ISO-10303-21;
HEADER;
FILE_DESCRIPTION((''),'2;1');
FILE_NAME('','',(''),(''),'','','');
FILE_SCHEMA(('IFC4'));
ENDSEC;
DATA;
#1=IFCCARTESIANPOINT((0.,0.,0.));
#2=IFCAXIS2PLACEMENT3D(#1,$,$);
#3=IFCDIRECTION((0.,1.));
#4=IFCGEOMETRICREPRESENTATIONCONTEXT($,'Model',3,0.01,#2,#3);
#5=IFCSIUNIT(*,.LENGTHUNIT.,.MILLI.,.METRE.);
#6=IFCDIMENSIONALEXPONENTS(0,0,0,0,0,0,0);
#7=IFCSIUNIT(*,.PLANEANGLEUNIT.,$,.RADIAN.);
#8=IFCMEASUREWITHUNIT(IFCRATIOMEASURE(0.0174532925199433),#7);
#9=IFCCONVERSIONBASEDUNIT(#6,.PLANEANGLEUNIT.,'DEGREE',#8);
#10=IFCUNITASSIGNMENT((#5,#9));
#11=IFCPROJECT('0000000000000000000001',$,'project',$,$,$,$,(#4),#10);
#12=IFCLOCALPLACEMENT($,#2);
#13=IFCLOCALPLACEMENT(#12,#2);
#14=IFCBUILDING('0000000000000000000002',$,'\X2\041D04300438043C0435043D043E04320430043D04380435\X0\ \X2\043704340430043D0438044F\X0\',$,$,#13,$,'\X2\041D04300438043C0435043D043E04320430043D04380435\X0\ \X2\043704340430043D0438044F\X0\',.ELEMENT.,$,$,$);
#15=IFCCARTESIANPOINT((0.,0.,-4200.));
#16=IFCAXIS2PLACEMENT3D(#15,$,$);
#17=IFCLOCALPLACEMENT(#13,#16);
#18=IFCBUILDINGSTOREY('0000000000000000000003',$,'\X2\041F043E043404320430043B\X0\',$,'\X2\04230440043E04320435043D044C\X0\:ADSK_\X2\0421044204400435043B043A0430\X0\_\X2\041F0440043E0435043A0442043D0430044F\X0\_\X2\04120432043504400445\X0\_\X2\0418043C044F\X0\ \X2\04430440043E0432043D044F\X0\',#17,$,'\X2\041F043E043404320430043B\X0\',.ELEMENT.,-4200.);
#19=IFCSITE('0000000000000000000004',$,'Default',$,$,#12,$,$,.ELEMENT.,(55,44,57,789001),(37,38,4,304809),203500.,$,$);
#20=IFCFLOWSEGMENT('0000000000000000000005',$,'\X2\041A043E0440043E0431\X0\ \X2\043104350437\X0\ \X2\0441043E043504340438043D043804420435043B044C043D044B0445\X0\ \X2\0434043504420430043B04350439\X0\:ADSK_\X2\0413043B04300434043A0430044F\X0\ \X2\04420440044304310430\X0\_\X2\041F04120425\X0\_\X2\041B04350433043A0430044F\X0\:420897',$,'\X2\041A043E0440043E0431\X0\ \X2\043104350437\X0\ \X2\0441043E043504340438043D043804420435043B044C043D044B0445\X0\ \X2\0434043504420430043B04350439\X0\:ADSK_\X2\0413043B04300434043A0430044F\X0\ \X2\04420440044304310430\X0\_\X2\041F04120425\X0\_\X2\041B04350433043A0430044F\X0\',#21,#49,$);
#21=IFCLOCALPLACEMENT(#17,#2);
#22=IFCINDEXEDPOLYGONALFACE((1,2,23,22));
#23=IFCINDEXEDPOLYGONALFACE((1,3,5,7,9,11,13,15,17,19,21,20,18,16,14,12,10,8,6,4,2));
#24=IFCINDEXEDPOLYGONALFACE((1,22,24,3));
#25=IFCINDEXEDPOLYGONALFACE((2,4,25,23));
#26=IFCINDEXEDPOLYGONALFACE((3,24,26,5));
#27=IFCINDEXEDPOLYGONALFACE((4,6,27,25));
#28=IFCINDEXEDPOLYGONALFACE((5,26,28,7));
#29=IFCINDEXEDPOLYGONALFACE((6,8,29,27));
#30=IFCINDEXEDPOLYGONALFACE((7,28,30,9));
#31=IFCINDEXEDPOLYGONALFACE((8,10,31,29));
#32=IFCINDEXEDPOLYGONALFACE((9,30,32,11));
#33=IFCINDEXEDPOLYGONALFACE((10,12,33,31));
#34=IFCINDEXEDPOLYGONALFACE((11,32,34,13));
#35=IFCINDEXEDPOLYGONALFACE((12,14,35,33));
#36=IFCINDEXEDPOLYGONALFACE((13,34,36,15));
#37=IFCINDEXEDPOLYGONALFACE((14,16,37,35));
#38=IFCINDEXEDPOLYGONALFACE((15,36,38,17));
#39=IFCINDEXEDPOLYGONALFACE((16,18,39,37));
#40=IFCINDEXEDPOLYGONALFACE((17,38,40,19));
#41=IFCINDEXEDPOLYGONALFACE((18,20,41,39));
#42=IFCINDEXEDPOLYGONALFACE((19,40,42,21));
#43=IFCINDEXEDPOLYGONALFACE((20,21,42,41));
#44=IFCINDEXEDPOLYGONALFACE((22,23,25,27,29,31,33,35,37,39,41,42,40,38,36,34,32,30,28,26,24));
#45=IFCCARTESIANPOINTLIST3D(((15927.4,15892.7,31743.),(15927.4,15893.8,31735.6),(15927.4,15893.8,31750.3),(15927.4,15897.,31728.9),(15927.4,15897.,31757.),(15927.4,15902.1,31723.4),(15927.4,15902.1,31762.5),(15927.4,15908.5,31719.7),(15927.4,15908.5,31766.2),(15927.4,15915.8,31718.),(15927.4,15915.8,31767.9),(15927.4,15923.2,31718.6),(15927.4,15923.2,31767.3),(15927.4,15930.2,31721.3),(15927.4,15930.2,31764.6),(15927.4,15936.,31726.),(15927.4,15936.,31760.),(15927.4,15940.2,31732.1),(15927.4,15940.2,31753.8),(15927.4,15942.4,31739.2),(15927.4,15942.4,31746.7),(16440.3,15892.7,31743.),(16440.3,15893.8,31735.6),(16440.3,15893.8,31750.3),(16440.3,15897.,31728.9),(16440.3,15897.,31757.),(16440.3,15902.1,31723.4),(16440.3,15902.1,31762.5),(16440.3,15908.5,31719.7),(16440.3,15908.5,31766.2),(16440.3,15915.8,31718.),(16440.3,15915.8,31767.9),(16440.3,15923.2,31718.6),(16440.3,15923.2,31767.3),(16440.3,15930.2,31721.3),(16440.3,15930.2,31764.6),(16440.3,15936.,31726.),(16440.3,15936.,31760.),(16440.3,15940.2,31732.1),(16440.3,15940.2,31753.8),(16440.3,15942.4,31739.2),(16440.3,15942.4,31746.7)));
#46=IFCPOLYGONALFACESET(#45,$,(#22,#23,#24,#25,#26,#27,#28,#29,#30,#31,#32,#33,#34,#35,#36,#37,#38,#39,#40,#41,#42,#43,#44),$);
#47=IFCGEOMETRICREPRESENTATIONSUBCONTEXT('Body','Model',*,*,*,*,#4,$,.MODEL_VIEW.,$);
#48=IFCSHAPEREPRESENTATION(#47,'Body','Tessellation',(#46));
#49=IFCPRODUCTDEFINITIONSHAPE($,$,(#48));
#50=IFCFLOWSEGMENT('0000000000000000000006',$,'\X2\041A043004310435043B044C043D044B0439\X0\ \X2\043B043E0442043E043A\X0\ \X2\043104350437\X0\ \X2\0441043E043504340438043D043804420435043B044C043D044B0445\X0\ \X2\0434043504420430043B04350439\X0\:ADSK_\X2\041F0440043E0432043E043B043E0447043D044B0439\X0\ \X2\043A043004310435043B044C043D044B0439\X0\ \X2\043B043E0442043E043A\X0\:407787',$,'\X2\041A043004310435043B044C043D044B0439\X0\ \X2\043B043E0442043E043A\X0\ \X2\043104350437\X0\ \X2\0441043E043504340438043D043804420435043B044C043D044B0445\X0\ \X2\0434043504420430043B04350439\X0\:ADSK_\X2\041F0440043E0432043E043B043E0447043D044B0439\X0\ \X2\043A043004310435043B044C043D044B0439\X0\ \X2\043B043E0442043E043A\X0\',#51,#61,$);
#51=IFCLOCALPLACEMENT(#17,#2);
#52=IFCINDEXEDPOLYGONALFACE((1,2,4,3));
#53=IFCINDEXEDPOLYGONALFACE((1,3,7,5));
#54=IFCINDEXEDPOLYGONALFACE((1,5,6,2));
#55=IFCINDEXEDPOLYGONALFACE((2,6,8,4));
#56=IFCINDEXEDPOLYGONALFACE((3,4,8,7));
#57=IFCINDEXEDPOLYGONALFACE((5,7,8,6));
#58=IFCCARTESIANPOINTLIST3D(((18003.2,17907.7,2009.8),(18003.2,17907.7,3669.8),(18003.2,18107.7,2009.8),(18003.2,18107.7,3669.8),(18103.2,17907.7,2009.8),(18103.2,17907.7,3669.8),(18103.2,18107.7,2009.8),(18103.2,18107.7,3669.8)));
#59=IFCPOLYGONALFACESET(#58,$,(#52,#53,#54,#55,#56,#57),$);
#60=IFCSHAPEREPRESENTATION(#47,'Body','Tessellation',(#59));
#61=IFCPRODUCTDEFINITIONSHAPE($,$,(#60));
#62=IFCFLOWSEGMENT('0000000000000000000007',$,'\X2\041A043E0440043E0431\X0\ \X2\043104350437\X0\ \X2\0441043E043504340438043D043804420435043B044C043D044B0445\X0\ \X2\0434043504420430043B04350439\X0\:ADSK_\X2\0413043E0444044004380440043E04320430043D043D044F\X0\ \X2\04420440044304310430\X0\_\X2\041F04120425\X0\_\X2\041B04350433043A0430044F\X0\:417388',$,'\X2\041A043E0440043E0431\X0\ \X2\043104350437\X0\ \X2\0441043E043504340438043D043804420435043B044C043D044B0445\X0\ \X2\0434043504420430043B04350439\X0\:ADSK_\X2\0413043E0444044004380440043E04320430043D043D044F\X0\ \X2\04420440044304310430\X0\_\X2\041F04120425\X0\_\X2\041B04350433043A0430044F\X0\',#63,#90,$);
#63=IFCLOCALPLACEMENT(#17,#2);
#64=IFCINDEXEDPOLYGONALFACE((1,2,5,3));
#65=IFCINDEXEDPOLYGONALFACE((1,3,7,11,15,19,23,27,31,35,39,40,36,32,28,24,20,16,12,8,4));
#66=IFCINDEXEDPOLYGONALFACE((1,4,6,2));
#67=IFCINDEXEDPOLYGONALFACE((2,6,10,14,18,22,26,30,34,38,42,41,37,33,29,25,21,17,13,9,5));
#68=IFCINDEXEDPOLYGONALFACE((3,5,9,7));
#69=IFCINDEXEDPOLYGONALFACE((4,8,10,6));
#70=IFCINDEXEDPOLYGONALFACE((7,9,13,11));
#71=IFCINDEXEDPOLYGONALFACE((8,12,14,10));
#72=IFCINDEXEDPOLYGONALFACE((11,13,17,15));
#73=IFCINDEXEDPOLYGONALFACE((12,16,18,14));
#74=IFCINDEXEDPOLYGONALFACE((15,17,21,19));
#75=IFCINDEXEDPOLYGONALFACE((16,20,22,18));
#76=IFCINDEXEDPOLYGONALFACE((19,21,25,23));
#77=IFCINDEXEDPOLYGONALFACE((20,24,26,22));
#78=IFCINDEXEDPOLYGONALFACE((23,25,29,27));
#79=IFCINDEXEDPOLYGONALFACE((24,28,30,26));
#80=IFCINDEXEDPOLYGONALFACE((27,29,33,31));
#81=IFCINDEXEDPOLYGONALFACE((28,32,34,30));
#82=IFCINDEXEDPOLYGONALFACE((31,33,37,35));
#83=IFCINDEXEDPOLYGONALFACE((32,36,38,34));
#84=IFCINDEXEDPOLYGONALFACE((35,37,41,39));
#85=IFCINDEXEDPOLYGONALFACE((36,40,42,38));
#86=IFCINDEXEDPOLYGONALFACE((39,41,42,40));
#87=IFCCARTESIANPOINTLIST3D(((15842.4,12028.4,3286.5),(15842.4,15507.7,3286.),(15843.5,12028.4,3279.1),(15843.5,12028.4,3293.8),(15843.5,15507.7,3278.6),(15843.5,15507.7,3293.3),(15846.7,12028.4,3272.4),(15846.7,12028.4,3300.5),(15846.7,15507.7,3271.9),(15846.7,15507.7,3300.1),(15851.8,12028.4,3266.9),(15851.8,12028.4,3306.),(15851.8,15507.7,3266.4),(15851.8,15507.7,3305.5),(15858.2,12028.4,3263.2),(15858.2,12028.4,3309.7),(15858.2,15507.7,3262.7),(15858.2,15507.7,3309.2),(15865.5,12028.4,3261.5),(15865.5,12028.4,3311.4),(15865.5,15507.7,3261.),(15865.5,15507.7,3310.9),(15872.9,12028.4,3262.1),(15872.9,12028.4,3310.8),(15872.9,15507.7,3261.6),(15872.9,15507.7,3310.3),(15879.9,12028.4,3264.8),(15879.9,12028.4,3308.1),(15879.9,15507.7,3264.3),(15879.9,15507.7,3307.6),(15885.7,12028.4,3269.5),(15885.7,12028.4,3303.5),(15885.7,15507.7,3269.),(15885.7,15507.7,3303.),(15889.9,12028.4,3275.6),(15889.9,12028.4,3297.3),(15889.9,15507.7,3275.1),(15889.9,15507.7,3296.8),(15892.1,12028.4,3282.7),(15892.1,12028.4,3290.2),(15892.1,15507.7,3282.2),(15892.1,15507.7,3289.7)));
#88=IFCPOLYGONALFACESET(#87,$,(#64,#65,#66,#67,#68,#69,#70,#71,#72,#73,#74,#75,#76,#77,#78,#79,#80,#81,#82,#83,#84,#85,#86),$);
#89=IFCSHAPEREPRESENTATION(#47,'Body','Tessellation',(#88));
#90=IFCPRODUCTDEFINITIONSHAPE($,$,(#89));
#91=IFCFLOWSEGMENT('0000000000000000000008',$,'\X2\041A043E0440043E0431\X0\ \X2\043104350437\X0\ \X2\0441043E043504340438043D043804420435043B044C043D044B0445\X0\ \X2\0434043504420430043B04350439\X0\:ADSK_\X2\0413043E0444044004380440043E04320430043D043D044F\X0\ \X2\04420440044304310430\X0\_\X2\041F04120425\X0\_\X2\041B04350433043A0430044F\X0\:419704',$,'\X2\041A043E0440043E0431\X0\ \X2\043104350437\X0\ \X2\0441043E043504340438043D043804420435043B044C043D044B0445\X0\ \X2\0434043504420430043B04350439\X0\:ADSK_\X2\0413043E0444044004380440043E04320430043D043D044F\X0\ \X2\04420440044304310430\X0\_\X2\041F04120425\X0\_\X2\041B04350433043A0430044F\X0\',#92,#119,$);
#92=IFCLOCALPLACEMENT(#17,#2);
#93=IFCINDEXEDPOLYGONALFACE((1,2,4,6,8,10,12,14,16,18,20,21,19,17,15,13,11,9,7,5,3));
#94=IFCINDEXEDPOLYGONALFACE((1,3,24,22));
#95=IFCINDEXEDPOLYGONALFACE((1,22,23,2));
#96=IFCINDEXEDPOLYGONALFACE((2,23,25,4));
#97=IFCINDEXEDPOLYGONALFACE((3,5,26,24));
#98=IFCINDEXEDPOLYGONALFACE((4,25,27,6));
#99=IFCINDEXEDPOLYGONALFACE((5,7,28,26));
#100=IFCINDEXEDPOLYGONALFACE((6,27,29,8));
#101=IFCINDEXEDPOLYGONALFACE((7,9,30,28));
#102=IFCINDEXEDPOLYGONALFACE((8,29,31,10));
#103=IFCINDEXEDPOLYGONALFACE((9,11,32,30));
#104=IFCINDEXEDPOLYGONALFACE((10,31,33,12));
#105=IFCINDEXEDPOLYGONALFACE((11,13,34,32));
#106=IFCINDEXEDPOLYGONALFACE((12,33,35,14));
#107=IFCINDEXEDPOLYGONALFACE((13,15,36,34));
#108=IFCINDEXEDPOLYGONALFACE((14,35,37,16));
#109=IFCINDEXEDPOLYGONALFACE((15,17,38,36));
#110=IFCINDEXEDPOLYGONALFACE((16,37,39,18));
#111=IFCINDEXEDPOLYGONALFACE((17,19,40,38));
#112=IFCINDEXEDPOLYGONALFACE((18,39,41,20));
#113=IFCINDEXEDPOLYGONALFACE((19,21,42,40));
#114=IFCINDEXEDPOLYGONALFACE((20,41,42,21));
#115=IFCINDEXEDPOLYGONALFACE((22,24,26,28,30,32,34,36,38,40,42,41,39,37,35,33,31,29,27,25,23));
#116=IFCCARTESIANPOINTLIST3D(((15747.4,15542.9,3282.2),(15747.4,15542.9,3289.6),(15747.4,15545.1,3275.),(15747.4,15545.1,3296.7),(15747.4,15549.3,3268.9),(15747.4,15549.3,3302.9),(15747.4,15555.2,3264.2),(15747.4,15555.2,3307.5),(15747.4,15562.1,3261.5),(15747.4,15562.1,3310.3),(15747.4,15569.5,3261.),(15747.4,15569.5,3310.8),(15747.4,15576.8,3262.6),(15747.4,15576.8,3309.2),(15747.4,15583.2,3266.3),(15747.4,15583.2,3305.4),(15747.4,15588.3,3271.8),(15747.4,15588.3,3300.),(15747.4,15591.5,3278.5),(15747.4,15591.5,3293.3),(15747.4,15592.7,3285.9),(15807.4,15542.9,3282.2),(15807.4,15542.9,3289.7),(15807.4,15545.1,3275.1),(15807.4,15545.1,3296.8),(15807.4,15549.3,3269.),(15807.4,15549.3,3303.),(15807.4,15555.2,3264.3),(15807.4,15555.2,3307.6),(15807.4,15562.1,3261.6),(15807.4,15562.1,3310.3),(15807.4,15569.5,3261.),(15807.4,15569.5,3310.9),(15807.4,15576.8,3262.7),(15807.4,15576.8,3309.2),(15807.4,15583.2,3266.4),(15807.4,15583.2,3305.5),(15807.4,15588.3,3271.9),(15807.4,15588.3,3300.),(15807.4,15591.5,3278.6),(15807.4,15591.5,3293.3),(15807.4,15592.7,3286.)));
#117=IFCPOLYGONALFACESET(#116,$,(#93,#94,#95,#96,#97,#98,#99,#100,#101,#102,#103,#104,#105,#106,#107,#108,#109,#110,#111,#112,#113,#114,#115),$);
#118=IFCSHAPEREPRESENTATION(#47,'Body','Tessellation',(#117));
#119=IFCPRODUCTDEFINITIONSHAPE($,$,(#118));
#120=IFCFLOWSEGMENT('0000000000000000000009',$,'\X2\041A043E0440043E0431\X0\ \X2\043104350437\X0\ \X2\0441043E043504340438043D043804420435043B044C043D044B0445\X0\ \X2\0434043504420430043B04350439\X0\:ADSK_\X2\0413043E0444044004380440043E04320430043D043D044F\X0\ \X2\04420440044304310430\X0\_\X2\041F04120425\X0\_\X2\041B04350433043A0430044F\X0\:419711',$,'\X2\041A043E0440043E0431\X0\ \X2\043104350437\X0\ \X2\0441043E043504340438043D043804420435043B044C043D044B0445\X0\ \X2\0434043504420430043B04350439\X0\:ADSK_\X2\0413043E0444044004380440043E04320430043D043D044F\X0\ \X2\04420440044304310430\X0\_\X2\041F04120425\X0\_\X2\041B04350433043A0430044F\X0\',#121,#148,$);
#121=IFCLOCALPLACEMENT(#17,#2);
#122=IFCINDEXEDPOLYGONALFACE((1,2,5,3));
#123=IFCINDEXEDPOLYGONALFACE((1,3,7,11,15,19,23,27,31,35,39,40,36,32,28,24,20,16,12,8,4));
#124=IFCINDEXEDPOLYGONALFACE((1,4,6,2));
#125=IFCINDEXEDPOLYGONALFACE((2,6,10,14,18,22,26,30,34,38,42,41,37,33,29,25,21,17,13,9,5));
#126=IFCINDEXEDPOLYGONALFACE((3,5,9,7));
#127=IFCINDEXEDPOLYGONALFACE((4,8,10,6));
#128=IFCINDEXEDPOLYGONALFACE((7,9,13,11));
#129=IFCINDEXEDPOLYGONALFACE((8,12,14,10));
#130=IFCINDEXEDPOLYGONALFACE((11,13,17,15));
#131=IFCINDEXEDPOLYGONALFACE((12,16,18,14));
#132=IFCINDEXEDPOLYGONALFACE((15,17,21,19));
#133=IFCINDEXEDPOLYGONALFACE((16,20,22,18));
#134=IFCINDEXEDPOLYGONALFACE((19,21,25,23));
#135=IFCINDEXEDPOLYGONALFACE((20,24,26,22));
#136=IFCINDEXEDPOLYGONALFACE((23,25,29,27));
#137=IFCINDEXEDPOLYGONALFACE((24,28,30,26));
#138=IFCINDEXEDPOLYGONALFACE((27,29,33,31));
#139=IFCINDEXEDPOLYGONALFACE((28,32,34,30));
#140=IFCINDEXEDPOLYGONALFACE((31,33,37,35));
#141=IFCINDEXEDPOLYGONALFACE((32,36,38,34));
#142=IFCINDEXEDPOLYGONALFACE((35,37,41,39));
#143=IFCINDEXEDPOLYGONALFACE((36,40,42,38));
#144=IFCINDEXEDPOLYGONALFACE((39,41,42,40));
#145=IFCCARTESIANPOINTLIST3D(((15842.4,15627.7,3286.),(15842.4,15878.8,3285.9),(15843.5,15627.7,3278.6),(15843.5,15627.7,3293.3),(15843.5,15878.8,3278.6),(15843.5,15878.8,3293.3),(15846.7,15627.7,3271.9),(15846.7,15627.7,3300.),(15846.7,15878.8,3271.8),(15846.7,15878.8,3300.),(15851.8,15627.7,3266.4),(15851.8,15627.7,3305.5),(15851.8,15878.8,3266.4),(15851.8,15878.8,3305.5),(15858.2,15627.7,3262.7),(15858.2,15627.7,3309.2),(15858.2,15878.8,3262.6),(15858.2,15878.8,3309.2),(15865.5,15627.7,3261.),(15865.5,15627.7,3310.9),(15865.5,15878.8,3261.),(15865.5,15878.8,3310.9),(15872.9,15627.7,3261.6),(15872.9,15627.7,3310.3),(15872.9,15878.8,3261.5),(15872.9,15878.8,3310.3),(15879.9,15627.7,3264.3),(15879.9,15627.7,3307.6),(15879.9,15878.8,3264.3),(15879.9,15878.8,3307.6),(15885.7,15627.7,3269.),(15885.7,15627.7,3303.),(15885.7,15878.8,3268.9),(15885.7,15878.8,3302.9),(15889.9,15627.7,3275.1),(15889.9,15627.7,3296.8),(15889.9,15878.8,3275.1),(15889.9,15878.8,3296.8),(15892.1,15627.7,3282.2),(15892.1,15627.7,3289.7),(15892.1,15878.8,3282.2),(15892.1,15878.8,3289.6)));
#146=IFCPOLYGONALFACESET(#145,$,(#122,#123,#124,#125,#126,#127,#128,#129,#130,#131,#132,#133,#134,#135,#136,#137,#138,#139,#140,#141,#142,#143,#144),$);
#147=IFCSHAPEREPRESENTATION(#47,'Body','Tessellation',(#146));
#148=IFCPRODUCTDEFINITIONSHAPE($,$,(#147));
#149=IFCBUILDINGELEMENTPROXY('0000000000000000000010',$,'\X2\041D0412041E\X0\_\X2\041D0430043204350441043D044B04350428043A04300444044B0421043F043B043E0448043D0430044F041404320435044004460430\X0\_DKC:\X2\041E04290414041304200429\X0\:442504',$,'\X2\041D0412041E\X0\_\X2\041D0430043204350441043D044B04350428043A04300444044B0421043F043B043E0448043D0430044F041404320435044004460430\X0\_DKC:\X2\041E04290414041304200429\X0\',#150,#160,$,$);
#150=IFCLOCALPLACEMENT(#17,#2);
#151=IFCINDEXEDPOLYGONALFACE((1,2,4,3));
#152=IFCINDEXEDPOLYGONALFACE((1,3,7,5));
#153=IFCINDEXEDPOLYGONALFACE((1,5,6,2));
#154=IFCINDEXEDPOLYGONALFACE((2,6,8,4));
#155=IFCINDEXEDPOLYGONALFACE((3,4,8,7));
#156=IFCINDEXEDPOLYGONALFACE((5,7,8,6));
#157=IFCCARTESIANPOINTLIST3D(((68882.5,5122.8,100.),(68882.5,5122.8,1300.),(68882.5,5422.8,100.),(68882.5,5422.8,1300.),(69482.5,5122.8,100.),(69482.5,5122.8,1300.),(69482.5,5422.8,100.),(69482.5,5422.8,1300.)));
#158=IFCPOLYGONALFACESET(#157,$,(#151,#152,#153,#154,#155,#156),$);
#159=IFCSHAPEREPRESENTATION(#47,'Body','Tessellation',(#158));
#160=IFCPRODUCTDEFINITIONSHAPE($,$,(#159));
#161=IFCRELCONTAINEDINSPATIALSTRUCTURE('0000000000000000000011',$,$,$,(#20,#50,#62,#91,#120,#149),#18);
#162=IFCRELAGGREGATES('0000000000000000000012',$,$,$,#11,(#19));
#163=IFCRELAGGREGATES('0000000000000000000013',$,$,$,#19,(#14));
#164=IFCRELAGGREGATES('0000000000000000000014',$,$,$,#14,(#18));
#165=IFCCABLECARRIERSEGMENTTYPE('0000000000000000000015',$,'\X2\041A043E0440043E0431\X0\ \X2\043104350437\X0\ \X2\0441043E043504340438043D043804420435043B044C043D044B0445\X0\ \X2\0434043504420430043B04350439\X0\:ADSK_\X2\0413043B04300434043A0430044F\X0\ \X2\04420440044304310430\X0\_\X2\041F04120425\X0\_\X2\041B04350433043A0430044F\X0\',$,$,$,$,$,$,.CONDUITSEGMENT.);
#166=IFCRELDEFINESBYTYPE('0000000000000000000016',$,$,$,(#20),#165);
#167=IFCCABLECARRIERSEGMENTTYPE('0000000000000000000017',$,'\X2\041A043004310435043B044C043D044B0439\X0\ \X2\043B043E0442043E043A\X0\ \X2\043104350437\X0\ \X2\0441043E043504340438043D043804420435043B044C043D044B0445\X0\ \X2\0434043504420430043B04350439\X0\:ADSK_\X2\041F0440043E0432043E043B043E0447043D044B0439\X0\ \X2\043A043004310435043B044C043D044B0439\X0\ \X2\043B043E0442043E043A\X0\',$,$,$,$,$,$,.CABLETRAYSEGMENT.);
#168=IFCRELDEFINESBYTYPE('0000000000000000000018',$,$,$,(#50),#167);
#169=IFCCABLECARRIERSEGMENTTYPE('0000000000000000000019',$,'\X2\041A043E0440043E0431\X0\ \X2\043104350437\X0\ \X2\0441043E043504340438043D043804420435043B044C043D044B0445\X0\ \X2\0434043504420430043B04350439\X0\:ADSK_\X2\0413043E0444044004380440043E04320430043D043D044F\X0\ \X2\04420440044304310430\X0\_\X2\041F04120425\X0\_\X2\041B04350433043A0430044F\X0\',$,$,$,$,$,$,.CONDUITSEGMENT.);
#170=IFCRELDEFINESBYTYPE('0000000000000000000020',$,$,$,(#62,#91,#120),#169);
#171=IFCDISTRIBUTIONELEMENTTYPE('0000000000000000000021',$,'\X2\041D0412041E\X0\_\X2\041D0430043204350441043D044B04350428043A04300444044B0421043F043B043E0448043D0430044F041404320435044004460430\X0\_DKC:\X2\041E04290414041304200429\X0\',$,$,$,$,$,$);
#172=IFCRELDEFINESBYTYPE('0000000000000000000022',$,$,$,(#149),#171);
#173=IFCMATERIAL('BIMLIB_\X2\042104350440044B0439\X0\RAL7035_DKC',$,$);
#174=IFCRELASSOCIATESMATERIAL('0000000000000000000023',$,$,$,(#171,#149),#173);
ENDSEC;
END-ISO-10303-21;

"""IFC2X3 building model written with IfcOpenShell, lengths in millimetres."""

from ifc_helpers import new_model, entity, si_unit, converted_unit, direction, frame, frame_2d, origin, origin_2d_with_axis, place, context, subcontext, project, spatial, rectangle, circle, extrude, source, transform, mapped, material, type_object, type_shapes, element, save


model = new_model("IFC2X3")

# Units and contexts
model_context = context("Model", 3, precision=0.01, world=origin(), true_north=direction((0.0, 1.0)))
body_context = subcontext(model_context, "Body", "Model", "MODEL_VIEW")
ifc_project = project(units=[si_unit("LENGTHUNIT", "METRE", prefix="MILLI"), converted_unit("PLANEANGLEUNIT", "DEGREE", entity("IfcRatioMeasure", 0.0174532925199433), si_unit("PLANEANGLEUNIT", "RADIAN"), dimensions=[0, 0, 0, 0, 0, 0, 0])], contexts=[model_context])

# Site, building, storey
site_placement = place(None, frame((0.0, 0.0, 0.0)))
site = spatial("IfcSite", under=ifc_project, at=site_placement, Name="Default", CompositionType="ELEMENT", RefLatitude=(55, 44, 57, 789001), RefLongitude=(37, 38, 4, 304809), RefElevation=203500.0)
building_placement = place(site_placement, origin())
building = spatial("IfcBuilding", under=site, at=building_placement, Name="Наименование здания", LongName="Наименование здания", CompositionType="ELEMENT")
storey_placement = place(building_placement, frame((0.0, 0.0, -4200.0)))
storey = spatial("IfcBuildingStorey", under=building, at=storey_placement, Name="Подвал", ObjectType="Уровень:ADSK_Стрелка_Проектная_Вверх_Имя уровня", LongName="Подвал", CompositionType="ELEMENT", Elevation=-4200.0)

# Flow segments
cable_carrier_segment_type_1 = type_object("IfcCableCarrierSegmentType", Name="Короб без соединительных деталей:ADSK_Гладкая труба_ПВХ_Легкая", PredefinedType="CONDUITSEGMENT")
flow_segment_1_placement = place(storey_placement, frame((15927.4, 15891.1, 31716.4)))
element("IfcFlowSegment", 1, at=flow_segment_1_placement, inside=storey, type_object=cable_carrier_segment_type_1, Name="Короб без соединительных деталей:ADSK_Гладкая труба_ПВХ_Легкая:420897", ObjectType="Короб без соединительных деталей:ADSK_Гладкая труба_ПВХ_Легкая", context=body_context, shape_type="SweptSolid", body=[
    extrude(circle(Radius=25.0, at=frame_2d((0.0, 0.0), x_axis=(1.0, 0.0))), frame((0.0, 26.6, 26.6), z_axis=(1.0, -0.000004, 0.0), x_axis=(-0.000004, -1.0, 0.0)), (0.0, 0.0, 1.0), 513.0),
])
cable_carrier_segment_type_2 = type_object("IfcCableCarrierSegmentType", Name="Кабельный лоток без соединительных деталей:ADSK_Проволочный кабельный лоток", PredefinedType="CABLETRAYSEGMENT")
flow_segment_2_placement = place(storey_placement, frame((18003.2, 17907.7, 2009.8)))
element("IfcFlowSegment", 2, at=flow_segment_2_placement, inside=storey, type_object=cable_carrier_segment_type_2, Name="Кабельный лоток без соединительных деталей:ADSK_Проволочный кабельный лоток:407787", ObjectType="Кабельный лоток без соединительных деталей:ADSK_Проволочный кабельный лоток", context=body_context, shape_type="SweptSolid", body=[
    extrude(rectangle(XDim=200.0, YDim=100.0, at=origin_2d_with_axis()), frame((50.0, 100.0, 0.0), z_axis=(0.0, 0.0, 1.0), x_axis=(0.0, 1.0, 0.0)), (0.0, 0.0, 1.0), 1660.0),
])
cable_carrier_segment_type_3 = type_object("IfcCableCarrierSegmentType", Name="Короб без соединительных деталей:ADSK_Гофрировання труба_ПВХ_Легкая", PredefinedType="CONDUITSEGMENT")
flow_segment_3_placement = place(storey_placement, frame((15840.8, 12028.4, 3259.4)))
element("IfcFlowSegment", 3, at=flow_segment_3_placement, inside=storey, type_object=cable_carrier_segment_type_3, Name="Короб без соединительных деталей:ADSK_Гофрировання труба_ПВХ_Легкая:417388", ObjectType="Короб без соединительных деталей:ADSK_Гофрировання труба_ПВХ_Легкая", context=body_context, shape_type="SweptSolid", body=[
    extrude(circle(Radius=25.0, at=frame_2d((0.0, 0.0), x_axis=(1.0, 0.0))), frame((26.6, 0.0, 27.1), z_axis=(0.0, 1.0, -0.000139), x_axis=(-1.0, 0.0, 0.0)), (0.0, 0.0, 1.0), 3479.2),
])
flow_segment_4_placement = place(storey_placement, frame((15747.4, 15541.1, 3259.3)))
element("IfcFlowSegment", 4, at=flow_segment_4_placement, inside=storey, type_object=cable_carrier_segment_type_3, Name="Короб без соединительных деталей:ADSK_Гофрировання труба_ПВХ_Легкая:419704", ObjectType="Короб без соединительных деталей:ADSK_Гофрировання труба_ПВХ_Легкая", context=body_context, shape_type="SweptSolid", body=[
    extrude(circle(Radius=25.0, at=frame_2d((0.0, 0.0), x_axis=(1.0, 0.0))), frame((0.0, 26.6, 26.6), z_axis=(0.999999, 0.0, 0.001165), x_axis=(0.0, 1.0, 0.0)), (0.0, 0.0, 1.0), 60.0),
])
flow_segment_5_placement = place(storey_placement, frame((15840.8, 15627.7, 3259.3)))
element("IfcFlowSegment", 5, at=flow_segment_5_placement, inside=storey, type_object=cable_carrier_segment_type_3, Name="Короб без соединительных деталей:ADSK_Гофрировання труба_ПВХ_Легкая:419711", ObjectType="Короб без соединительных деталей:ADSK_Гофрировання труба_ПВХ_Легкая", context=body_context, shape_type="SweptSolid", body=[
    extrude(circle(Radius=25.0, at=frame_2d((0.0, 0.0), x_axis=(1.0, 0.0))), frame((26.6, 251.1, 26.6), z_axis=(0.0, -1.0, 0.000139), x_axis=(-1.0, 0.0, 0.0)), (0.0, 0.0, 1.0), 251.1),
])

# Electric distribution point
ifc_material = material(Name="BIMLIB_СерыйRAL7035_DKC")
distribution_element_type = type_object("IfcDistributionElementType", Name="НВО_НавесныеШкафыСплошнаяДверца_DKC:ОЩДГРЩ", material=ifc_material)
shared_shape = source(origin(), body_context, "Body", "SweptSolid", [
    extrude(rectangle(XDim=600.0, YDim=300.0, at=origin_2d_with_axis()), frame((300.0, 150.0, 0.0), z_axis=(0.0, 0.0, 1.0), x_axis=(-1.0, 0.0, 0.0)), (0.0, 0.0, 1.0), 1200.0),
])
type_shapes(distribution_element_type, [shared_shape])
electric_distribution_point_placement = place(storey_placement, frame((68882.5, 5122.8, 100.0)))
element("IfcElectricDistributionPoint", 6, at=electric_distribution_point_placement, inside=storey, type_object=distribution_element_type, material=ifc_material, Name="НВО_НавесныеШкафыСплошнаяДверца_DKC:ОЩДГРЩ:442504", ObjectType="НВО_НавесныеШкафыСплошнаяДверца_DKC:ОЩДГРЩ", DistributionPointFunction="DISTRIBUTIONBOARD", context=body_context, shape_type="MappedRepresentation", body=[
    mapped(shared_shape, transform((0.0, 0.0, 0.0), scale=1.0)),
])

save(model, "model.ifc")
